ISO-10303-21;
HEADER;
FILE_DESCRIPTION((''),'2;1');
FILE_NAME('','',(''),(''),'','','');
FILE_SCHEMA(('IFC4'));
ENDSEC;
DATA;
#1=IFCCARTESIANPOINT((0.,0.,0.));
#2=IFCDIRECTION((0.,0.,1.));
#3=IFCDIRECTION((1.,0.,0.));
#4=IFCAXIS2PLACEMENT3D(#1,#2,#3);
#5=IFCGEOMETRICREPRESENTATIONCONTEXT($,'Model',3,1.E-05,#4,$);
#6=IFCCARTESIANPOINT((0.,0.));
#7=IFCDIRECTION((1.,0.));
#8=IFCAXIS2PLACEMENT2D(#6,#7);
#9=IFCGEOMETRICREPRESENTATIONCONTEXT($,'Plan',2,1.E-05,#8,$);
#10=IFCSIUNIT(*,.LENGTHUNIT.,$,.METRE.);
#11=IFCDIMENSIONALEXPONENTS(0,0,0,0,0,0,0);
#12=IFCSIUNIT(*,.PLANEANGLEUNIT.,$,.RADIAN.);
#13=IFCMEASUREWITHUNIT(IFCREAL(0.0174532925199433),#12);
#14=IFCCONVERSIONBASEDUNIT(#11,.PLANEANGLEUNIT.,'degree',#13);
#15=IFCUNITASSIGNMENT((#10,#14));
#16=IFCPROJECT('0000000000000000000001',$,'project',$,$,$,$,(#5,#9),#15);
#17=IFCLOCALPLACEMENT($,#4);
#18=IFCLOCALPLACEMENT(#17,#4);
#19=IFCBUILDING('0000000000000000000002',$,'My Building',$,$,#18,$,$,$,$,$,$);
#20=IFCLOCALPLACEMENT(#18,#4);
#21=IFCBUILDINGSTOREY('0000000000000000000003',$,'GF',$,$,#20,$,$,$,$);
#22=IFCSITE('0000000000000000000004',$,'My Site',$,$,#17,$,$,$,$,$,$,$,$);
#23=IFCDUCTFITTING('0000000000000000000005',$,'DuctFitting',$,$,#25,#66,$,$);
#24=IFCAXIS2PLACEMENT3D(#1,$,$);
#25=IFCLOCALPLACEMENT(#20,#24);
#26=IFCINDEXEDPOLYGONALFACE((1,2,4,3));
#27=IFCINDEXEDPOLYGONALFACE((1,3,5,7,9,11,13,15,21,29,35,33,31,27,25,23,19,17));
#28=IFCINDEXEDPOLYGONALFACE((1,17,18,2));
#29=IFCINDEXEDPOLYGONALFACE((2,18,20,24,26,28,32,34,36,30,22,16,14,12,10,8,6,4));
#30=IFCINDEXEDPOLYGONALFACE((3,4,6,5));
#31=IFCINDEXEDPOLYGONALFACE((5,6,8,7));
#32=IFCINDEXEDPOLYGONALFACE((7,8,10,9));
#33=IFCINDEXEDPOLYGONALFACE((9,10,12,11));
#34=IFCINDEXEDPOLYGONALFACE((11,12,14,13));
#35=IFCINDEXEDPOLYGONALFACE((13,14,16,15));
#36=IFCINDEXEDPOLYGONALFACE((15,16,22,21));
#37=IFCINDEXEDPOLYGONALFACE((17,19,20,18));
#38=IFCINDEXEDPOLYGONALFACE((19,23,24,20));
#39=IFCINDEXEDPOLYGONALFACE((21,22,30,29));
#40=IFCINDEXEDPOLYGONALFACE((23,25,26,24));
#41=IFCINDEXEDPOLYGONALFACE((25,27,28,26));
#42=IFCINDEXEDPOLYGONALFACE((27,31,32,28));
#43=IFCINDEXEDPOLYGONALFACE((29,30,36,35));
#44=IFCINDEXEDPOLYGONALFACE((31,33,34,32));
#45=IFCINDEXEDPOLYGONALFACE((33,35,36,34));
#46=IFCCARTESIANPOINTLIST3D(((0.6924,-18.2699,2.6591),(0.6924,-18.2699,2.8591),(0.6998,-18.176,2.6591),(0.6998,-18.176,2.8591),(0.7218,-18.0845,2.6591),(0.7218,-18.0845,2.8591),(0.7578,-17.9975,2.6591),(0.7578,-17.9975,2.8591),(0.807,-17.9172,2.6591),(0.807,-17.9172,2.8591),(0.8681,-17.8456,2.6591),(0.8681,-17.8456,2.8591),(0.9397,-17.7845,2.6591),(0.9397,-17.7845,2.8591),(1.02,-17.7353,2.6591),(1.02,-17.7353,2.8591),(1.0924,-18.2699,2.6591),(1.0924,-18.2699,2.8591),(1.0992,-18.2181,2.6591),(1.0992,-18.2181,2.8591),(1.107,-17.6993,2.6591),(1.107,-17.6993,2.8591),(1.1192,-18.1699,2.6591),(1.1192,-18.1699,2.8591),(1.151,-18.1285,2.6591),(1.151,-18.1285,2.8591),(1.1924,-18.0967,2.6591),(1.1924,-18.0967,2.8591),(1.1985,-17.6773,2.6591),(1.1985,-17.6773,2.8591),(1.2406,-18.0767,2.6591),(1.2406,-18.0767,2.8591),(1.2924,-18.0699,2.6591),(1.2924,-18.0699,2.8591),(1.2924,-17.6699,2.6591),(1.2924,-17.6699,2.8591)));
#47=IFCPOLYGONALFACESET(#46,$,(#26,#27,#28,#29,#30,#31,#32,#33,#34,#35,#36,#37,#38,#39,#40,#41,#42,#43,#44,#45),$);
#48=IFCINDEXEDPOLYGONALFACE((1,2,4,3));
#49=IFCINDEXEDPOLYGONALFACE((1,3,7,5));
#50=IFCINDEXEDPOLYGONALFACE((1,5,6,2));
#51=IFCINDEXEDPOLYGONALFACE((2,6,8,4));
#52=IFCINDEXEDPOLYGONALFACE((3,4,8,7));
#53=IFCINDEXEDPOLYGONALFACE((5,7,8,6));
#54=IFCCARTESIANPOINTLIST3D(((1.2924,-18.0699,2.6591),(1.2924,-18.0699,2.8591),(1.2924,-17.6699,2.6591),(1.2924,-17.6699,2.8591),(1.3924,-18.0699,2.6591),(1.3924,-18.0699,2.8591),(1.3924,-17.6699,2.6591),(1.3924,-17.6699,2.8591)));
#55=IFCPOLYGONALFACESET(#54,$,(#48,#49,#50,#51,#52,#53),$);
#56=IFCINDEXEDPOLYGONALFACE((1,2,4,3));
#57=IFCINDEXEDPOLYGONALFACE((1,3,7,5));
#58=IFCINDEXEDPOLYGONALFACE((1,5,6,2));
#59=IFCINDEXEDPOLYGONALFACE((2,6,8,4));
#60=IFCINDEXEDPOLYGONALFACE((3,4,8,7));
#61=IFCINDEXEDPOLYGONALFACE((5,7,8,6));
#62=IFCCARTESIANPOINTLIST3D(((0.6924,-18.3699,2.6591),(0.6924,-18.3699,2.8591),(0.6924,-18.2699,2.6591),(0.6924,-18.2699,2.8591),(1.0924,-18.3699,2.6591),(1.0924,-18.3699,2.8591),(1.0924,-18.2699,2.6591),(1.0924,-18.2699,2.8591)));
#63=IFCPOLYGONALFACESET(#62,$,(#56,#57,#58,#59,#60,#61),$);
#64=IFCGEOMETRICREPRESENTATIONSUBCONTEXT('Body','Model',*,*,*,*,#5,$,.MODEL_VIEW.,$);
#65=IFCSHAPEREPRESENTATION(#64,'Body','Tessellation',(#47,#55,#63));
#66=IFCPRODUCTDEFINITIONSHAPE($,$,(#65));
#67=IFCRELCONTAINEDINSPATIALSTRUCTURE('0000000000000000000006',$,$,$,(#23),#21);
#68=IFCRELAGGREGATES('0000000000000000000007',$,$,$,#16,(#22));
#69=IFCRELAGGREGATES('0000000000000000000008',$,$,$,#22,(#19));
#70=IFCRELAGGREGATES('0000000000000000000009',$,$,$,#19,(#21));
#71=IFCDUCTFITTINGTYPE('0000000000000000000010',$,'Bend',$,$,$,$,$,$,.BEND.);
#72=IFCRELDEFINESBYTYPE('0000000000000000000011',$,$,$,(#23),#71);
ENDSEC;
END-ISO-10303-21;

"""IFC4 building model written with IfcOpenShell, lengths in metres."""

from ifc_helpers import new_model, entity, si_unit, converted_unit, frame, origin_with_axes, origin_2d_with_axis, place, context, subcontext, project, spatial, line, arc, indexed_curve, rectangle, outline, extrude, source, transform, mapped, type_object, type_shapes, element, save


model = new_model("IFC4")

# Units and contexts
model_context = context("Model", 3, precision=1e-05, world=origin_with_axes())
plan_context = context("Plan", 2, precision=1e-05, world=origin_2d_with_axis())
body_context_1 = subcontext(model_context, "Body", "Model", "MODEL_VIEW")
ifc_project = project(units=[si_unit("LENGTHUNIT", "METRE"), converted_unit("PLANEANGLEUNIT", "degree", entity("IfcReal", 0.0174532925199433), si_unit("PLANEANGLEUNIT", "RADIAN"), dimensions=[0, 0, 0, 0, 0, 0, 0])], contexts=[model_context, plan_context])

# Site, building, storey
site_placement = place(None, origin_with_axes())
site = spatial("IfcSite", under=ifc_project, at=site_placement, Name="My Site")
building_placement = place(site_placement, origin_with_axes())
building = spatial("IfcBuilding", under=site, at=building_placement, Name="My Building")
storey_placement = place(building_placement, origin_with_axes())
storey = spatial("IfcBuildingStorey", under=building, at=storey_placement, Name="GF")

# Duct fitting
duct_fitting_type = type_object("IfcDuctFittingType", Name="Bend", PredefinedType="BEND")
shared_shape_1 = source(origin_with_axes(), body_context_1, "Body", "SweptSolid", [
    extrude(outline(indexed_curve([(-0.2, 0.0), (-0.2586, -0.1414), (-0.4, -0.2), (-0.4, -0.6), (0.0243, -0.4243), (0.2, 0.0)], segments=[arc(1, 2, 3), line(3, 4), arc(4, 5, 6), line(6, 1)])), frame((0.0, -0.1, -0.1), z_axis=(0.0, -1.0, 0.0), x_axis=(1.0, 0.0, 0.0)), (0.0, 0.0, -1.0), 0.2),
    extrude(rectangle(XDim=0.4, YDim=0.2), origin_with_axes(), (0.0, 0.0, -1.0), 0.1),
    extrude(rectangle(XDim=0.4, YDim=0.2), frame((-0.4, 0.0, -0.5), z_axis=(-1.0, 0.0, 0.0), x_axis=(0.0, 0.0, -1.0)), (0.0, 0.0, 1.0), 0.1),
])
type_shapes(duct_fitting_type, [shared_shape_1])
for number, where, z_axis, x_axis, name in (
    (1, (1.3924, -17.8699, 2.7591), (1.0, 0.0, 0.0), (0.0, 1.0, 0.0), "DuctFitting"),
):
    element("IfcDuctFitting", number, at=place(storey_placement, frame(where, z_axis=z_axis, x_axis=x_axis)), inside=storey, type_object=duct_fitting_type, Name=name, context=body_context_1, shape_type="MappedRepresentation", body=[
        mapped(shared_shape_1, transform((0.0, 0.0, 0.0), x_axis=(1.0, 0.0, 0.0), y_axis=(0.0, 1.0, 0.0), z_axis=(0.0, 0.0, 1.0), scale=1.0)),
    ])

save(model, "model.ifc")
